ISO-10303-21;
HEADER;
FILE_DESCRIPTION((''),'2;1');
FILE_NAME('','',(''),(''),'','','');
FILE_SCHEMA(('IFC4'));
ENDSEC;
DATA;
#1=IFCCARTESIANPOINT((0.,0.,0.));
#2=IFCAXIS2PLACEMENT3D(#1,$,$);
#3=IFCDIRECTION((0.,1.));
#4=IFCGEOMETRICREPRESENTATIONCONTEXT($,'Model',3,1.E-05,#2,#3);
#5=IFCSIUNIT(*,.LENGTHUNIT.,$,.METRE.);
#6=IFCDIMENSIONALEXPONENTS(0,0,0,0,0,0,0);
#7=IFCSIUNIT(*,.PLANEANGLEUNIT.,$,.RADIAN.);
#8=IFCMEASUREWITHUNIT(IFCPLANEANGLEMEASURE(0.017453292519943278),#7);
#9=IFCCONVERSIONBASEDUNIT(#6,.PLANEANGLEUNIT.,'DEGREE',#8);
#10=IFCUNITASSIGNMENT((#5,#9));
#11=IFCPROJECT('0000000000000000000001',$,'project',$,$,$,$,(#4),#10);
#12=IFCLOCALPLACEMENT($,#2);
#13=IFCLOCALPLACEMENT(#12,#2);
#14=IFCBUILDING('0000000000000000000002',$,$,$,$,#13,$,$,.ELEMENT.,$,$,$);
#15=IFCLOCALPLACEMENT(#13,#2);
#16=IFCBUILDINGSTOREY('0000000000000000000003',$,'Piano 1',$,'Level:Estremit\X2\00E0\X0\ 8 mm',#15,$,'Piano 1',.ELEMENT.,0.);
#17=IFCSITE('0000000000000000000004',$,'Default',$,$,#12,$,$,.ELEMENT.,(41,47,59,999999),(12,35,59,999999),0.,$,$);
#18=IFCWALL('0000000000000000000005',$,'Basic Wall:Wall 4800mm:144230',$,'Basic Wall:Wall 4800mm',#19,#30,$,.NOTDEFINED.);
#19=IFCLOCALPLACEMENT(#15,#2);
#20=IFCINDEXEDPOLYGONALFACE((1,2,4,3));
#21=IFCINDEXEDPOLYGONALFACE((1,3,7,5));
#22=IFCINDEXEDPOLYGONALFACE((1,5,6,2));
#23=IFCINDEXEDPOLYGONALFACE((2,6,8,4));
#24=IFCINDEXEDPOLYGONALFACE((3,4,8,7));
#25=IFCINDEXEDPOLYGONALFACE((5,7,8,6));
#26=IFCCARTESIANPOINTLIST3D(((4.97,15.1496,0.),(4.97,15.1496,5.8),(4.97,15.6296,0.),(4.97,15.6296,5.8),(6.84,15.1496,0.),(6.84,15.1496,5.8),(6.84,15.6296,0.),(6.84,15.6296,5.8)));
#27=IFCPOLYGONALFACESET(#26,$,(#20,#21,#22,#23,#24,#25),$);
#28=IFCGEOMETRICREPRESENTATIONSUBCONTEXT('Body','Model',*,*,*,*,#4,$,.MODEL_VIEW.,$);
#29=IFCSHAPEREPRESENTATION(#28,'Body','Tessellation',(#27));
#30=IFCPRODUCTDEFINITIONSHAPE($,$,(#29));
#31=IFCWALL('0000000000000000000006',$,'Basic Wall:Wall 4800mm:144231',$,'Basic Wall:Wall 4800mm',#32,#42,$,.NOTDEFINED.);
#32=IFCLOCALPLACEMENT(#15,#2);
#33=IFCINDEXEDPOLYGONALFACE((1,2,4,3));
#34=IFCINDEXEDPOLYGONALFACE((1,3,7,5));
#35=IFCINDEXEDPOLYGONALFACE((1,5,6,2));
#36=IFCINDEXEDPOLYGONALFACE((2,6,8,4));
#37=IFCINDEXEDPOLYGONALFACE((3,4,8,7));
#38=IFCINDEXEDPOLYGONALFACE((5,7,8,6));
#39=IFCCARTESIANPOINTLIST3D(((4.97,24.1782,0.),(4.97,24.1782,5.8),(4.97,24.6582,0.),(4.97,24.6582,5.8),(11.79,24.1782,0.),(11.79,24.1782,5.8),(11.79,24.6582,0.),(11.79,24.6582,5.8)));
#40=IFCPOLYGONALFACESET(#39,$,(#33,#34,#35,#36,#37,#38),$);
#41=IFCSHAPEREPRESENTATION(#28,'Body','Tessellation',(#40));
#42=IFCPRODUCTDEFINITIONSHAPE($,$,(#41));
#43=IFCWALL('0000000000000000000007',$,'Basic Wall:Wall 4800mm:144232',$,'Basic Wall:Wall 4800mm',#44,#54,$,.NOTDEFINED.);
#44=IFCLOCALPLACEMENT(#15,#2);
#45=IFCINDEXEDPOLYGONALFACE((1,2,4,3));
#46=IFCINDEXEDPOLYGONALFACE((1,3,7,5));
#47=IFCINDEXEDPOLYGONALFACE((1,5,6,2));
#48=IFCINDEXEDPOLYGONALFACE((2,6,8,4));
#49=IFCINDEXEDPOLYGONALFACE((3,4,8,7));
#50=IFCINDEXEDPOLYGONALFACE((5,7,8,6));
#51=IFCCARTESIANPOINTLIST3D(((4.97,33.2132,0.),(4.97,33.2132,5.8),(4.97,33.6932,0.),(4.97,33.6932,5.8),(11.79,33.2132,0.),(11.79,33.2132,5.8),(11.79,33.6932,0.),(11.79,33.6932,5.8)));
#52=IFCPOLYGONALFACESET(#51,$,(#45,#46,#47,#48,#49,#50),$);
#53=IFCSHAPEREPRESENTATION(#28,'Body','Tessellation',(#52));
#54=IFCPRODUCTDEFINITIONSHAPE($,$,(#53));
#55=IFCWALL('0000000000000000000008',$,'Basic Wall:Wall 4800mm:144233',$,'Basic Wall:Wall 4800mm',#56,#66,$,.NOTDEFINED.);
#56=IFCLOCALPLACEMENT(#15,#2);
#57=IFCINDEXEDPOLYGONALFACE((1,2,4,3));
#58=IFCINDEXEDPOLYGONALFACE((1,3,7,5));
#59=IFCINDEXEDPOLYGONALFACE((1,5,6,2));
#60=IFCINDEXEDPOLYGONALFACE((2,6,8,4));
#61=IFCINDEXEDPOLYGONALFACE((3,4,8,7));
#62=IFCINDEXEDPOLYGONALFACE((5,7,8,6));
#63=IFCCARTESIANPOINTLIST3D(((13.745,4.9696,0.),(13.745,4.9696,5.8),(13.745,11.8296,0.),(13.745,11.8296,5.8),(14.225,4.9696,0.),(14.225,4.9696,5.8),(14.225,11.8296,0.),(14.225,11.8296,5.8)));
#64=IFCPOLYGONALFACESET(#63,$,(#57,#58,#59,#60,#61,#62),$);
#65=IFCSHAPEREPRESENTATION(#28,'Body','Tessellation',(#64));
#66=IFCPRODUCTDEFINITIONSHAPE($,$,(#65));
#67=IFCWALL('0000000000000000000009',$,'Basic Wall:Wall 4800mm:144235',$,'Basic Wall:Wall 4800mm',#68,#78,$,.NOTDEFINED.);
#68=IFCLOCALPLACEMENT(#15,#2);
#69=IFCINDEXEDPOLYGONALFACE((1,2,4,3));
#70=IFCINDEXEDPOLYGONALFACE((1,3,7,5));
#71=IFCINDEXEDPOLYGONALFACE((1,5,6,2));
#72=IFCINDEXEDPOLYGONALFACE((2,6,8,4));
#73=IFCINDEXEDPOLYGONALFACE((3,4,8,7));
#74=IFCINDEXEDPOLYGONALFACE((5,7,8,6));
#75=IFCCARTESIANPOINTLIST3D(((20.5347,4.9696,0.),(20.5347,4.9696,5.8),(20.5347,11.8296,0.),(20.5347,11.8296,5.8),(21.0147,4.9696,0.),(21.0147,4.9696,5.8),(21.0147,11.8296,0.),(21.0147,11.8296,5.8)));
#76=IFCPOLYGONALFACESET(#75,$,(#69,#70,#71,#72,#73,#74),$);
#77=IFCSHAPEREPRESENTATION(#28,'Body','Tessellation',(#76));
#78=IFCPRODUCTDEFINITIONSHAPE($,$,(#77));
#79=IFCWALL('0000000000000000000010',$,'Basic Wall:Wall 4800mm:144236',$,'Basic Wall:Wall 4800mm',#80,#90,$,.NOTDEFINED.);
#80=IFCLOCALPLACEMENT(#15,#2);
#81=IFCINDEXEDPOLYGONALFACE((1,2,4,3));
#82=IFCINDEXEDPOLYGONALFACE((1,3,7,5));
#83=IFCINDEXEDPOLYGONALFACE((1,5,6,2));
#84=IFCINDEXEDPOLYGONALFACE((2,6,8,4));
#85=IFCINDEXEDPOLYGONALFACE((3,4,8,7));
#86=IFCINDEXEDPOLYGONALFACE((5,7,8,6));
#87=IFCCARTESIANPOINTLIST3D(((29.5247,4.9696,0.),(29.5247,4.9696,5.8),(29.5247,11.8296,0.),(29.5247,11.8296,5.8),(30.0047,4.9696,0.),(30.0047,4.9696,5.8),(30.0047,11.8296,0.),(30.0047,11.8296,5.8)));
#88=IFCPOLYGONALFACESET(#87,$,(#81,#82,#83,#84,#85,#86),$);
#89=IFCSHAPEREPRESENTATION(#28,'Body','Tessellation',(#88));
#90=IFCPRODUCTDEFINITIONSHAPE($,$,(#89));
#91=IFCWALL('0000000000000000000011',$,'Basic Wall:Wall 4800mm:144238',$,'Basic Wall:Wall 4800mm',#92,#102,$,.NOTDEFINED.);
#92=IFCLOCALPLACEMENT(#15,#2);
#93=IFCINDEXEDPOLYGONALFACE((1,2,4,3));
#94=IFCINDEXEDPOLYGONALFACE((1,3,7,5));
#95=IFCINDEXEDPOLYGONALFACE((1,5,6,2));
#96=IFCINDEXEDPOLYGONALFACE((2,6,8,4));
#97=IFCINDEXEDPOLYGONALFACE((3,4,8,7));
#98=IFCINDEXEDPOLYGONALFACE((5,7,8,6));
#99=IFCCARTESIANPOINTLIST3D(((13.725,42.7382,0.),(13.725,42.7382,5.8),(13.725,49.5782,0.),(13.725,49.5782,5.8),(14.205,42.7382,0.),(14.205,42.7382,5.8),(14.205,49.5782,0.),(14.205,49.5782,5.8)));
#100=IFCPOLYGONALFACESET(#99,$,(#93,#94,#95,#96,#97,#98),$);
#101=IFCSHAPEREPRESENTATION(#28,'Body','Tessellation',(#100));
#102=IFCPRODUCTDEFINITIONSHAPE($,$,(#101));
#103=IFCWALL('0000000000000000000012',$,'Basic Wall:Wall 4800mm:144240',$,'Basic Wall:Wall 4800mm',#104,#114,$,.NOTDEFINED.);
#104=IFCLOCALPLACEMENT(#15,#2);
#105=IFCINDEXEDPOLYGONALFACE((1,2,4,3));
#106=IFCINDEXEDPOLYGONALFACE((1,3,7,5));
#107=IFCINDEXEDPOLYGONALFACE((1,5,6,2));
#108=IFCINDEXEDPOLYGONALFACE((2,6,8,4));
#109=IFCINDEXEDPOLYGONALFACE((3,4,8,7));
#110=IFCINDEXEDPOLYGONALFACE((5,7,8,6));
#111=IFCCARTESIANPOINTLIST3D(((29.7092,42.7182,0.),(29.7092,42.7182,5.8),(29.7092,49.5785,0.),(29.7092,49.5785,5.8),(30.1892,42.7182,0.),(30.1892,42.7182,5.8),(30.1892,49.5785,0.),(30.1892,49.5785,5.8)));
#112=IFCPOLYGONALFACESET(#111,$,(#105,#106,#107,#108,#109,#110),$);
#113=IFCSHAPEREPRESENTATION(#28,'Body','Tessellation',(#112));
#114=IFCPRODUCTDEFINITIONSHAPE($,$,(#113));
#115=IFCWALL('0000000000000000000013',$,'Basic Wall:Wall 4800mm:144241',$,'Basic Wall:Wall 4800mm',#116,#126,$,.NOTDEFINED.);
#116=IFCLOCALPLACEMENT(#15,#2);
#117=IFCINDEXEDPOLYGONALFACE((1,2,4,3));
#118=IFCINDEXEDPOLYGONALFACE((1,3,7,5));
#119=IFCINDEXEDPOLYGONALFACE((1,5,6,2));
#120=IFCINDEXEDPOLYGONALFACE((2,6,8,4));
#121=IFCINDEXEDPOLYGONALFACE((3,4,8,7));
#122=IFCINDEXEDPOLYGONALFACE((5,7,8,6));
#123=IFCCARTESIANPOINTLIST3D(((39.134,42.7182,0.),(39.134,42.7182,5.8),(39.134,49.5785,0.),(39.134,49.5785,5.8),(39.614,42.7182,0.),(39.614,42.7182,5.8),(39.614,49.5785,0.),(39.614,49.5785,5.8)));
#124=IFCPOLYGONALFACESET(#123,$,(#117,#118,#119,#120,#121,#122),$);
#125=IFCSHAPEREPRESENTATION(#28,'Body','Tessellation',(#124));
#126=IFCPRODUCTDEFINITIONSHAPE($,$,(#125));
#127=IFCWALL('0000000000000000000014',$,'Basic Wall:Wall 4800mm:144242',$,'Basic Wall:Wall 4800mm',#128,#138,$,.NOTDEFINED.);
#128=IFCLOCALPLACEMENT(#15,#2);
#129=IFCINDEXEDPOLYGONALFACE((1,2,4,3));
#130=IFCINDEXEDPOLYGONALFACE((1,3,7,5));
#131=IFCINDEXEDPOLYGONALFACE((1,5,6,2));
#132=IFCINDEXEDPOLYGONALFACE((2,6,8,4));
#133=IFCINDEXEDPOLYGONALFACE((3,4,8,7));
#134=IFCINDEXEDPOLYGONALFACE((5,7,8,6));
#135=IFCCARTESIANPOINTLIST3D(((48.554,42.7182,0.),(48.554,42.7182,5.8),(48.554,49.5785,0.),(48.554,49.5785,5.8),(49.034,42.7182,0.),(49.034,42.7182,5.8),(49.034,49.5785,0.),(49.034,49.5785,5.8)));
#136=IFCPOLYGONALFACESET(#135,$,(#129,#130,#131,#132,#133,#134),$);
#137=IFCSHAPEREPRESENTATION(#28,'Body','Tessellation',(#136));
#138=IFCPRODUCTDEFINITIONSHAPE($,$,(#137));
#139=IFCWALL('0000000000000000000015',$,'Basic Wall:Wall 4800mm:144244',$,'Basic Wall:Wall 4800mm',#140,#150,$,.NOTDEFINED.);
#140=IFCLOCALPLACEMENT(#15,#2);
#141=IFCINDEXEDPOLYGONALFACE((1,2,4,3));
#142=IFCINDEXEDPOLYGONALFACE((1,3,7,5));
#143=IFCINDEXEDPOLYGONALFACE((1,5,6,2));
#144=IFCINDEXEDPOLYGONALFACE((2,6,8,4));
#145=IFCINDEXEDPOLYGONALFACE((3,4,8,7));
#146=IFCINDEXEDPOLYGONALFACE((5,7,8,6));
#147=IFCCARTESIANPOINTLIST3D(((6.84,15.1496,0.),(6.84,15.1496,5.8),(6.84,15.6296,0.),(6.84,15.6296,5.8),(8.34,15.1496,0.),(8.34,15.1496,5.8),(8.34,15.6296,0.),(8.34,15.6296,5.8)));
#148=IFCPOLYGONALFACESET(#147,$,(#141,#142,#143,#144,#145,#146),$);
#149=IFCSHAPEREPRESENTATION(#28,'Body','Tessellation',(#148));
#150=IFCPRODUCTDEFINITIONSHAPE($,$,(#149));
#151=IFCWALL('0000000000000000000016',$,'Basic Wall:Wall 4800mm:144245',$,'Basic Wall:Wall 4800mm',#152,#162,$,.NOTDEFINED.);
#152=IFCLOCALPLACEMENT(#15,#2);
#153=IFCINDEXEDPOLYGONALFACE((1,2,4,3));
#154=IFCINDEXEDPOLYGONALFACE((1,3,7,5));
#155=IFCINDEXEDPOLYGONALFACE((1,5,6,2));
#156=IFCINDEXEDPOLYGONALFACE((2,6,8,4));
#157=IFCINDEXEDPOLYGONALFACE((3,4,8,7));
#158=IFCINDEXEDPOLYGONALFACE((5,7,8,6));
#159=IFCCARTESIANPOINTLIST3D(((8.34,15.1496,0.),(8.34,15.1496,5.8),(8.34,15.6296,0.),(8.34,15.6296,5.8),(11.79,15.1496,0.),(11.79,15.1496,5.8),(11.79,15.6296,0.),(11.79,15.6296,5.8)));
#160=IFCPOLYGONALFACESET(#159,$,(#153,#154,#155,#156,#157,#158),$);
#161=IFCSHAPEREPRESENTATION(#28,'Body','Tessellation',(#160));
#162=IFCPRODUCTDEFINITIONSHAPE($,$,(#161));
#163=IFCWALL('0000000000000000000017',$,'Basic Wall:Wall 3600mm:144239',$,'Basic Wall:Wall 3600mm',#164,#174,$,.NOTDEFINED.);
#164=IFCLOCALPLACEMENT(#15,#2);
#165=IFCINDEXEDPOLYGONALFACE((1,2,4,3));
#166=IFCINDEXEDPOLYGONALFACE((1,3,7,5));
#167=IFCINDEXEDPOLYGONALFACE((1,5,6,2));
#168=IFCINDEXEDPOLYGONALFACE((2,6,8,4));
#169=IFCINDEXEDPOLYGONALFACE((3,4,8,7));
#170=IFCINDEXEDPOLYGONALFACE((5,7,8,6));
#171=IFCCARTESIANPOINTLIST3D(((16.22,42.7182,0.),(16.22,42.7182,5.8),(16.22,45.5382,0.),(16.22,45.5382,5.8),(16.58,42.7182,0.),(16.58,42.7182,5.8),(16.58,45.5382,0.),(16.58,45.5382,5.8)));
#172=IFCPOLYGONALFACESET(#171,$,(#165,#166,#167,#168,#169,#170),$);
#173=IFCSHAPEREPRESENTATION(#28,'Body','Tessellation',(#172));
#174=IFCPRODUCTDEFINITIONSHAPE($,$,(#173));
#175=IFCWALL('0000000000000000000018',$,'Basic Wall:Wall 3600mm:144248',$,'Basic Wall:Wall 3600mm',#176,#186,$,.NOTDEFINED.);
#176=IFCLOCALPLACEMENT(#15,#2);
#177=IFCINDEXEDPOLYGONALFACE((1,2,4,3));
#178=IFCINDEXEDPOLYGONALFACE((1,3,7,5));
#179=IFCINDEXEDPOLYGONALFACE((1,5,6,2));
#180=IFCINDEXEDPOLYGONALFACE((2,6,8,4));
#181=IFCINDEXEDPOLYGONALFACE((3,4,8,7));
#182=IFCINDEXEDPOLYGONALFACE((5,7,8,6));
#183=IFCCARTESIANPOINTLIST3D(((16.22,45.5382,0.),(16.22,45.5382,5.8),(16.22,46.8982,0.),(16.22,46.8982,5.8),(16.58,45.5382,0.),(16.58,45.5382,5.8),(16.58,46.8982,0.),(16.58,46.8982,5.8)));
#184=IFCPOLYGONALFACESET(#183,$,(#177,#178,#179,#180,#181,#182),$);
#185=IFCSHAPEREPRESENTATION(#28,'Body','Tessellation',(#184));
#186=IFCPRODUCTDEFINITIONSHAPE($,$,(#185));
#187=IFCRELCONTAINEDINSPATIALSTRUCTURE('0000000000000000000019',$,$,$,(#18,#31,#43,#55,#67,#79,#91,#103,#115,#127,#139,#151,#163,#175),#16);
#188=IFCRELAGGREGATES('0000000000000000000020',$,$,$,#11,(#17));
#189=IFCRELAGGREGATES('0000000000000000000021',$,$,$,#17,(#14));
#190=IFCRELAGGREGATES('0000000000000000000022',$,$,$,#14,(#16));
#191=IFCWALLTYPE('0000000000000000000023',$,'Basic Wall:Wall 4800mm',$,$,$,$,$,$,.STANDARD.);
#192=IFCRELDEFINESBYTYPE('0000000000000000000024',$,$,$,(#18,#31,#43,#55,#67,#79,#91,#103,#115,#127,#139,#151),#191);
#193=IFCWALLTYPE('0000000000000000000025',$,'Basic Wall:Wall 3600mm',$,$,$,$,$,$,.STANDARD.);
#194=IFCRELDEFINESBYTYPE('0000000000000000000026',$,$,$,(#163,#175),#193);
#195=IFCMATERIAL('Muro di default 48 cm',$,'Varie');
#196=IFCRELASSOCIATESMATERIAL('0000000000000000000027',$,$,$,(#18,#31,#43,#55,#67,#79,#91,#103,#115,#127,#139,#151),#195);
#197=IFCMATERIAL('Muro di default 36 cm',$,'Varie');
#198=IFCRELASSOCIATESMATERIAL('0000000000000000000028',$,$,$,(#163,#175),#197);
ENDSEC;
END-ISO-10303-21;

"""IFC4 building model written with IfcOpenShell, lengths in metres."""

from ifc_helpers import new_model, entity, si_unit, converted_unit, direction, frame, origin, place, context, subcontext, project, spatial, indexed_curve, outline, extrude, material, type_object, element, save


model = new_model("IFC4")

# Units and contexts
model_context = context("Model", 3, precision=1e-05, world=origin(), true_north=direction((0.0, 1.0)))
body_context = subcontext(model_context, "Body", "Model", "MODEL_VIEW")
ifc_project = project(units=[si_unit("LENGTHUNIT", "METRE"), converted_unit("PLANEANGLEUNIT", "DEGREE", entity("IfcPlaneAngleMeasure", 0.017453292519943278), si_unit("PLANEANGLEUNIT", "RADIAN"), dimensions=[0, 0, 0, 0, 0, 0, 0])], contexts=[model_context])

# Site, building, storey
site_placement = place(None, origin())
site = spatial("IfcSite", under=ifc_project, at=site_placement, Name="Default", CompositionType="ELEMENT", RefLatitude=(41, 47, 59, 999999), RefLongitude=(12, 35, 59, 999999), RefElevation=0.0)
building_placement = place(site_placement, origin())
building = spatial("IfcBuilding", under=site, at=building_placement, CompositionType="ELEMENT")
storey_placement = place(building_placement, origin())
storey = spatial("IfcBuildingStorey", under=building, at=storey_placement, Name="Piano 1", ObjectType="Level:Estremità 8 mm", LongName="Piano 1", CompositionType="ELEMENT", Elevation=0.0)

# Walls
ifc_material_1 = material(Name="Muro di default 48 cm", Category="Varie")
wall_type_1 = type_object("IfcWallType", Name="Basic Wall:Wall 4800mm", PredefinedType="STANDARD")
wall_1_placement = place(storey_placement, frame((4.97, 15.3896, 0.0)))
element("IfcWall", 1, at=wall_1_placement, inside=storey, type_object=wall_type_1, material=ifc_material_1, Name="Basic Wall:Wall 4800mm:144230", ObjectType="Basic Wall:Wall 4800mm", PredefinedType="NOTDEFINED", context=body_context, shape_type="SweptSolid", body=[
    extrude(outline(indexed_curve([(1.87, 0.24), (0.0, 0.24), (0.0, -0.24), (1.87, -0.24), (1.87, 0.24)], self_intersect=False)), origin(), (0.0, 0.0, 1.0), 5.8),
])
wall_2_placement = place(storey_placement, frame((4.97, 24.4182, 0.0)))
element("IfcWall", 2, at=wall_2_placement, inside=storey, type_object=wall_type_1, material=ifc_material_1, Name="Basic Wall:Wall 4800mm:144231", ObjectType="Basic Wall:Wall 4800mm", PredefinedType="NOTDEFINED", context=body_context, shape_type="SweptSolid", body=[
    extrude(outline(indexed_curve([(6.82, 0.24), (0.0, 0.24), (0.0, -0.24), (6.82, -0.24), (6.82, 0.24)], self_intersect=False)), origin(), (0.0, 0.0, 1.0), 5.8),
])
wall_3_placement = place(storey_placement, frame((4.97, 33.4532, 0.0)))
element("IfcWall", 3, at=wall_3_placement, inside=storey, type_object=wall_type_1, material=ifc_material_1, Name="Basic Wall:Wall 4800mm:144232", ObjectType="Basic Wall:Wall 4800mm", PredefinedType="NOTDEFINED", context=body_context, shape_type="SweptSolid", body=[
    extrude(outline(indexed_curve([(6.82, 0.24), (0.0, 0.24), (0.0, -0.24), (6.82, -0.24), (6.82, 0.24)], self_intersect=False)), origin(), (0.0, 0.0, 1.0), 5.8),
])
wall_4_placement = place(storey_placement, frame((13.985, 4.9696, 0.0), z_axis=(0.0, 0.0, 1.0), x_axis=(0.0, 1.0, 0.0)))
element("IfcWall", 4, at=wall_4_placement, inside=storey, type_object=wall_type_1, material=ifc_material_1, Name="Basic Wall:Wall 4800mm:144233", ObjectType="Basic Wall:Wall 4800mm", PredefinedType="NOTDEFINED", context=body_context, shape_type="SweptSolid", body=[
    extrude(outline(indexed_curve([(6.86, 0.24), (0.0, 0.24), (0.0, -0.24), (6.86, -0.24), (6.86, 0.24)], self_intersect=False)), origin(), (0.0, 0.0, 1.0), 5.8),
])
for number, where, z_axis, x_axis, name in (
    (5, (20.7747, 4.9696, 0.0), (0.0, 0.0, 1.0), (0.0, 1.0, 0.0), "Basic Wall:Wall 4800mm:144235"),
    (6, (29.7647, 4.9696, 0.0), (0.0, 0.0, 1.0), (0.0, 1.0, 0.0), "Basic Wall:Wall 4800mm:144236"),
):
    element("IfcWall", number, at=place(storey_placement, frame(where, z_axis=z_axis, x_axis=x_axis)), inside=storey, type_object=wall_type_1, material=ifc_material_1, Name=name, ObjectType="Basic Wall:Wall 4800mm", PredefinedType="NOTDEFINED", context=body_context, shape_type="SweptSolid", body=[
        extrude(outline(indexed_curve([(6.86, 0.24), (0.0, 0.24), (0.0, -0.24), (6.86, -0.24), (6.86, 0.24)], self_intersect=False)), origin(), (0.0, 0.0, 1.0), 5.8),
    ])
wall_5_placement = place(storey_placement, frame((13.965, 42.7382, 0.0), z_axis=(0.0, 0.0, 1.0), x_axis=(0.0, 1.0, 0.0)))
element("IfcWall", 7, at=wall_5_placement, inside=storey, type_object=wall_type_1, material=ifc_material_1, Name="Basic Wall:Wall 4800mm:144238", ObjectType="Basic Wall:Wall 4800mm", PredefinedType="NOTDEFINED", context=body_context, shape_type="SweptSolid", body=[
    extrude(outline(indexed_curve([(6.84, 0.24), (0.0, 0.24), (0.0, -0.24), (6.84, -0.24), (6.84, 0.24)], self_intersect=False)), origin(), (0.0, 0.0, 1.0), 5.8),
])
wall_6_placement = place(storey_placement, frame((29.9492, 42.7182, 0.0), z_axis=(0.0, 0.0, 1.0), x_axis=(0.0, 1.0, 0.0)))
element("IfcWall", 8, at=wall_6_placement, inside=storey, type_object=wall_type_1, material=ifc_material_1, Name="Basic Wall:Wall 4800mm:144240", ObjectType="Basic Wall:Wall 4800mm", PredefinedType="NOTDEFINED", context=body_context, shape_type="SweptSolid", body=[
    extrude(outline(indexed_curve([(6.8603, 0.24), (0.0, 0.24), (0.0, -0.24), (6.8603, -0.24), (6.8603, 0.24)], self_intersect=False)), origin(), (0.0, 0.0, 1.0), 5.8),
])
for number, where, z_axis, x_axis, name in (
    (9, (39.374, 42.7182, 0.0), (0.0, 0.0, 1.0), (0.0, 1.0, 0.0), "Basic Wall:Wall 4800mm:144241"),
    (10, (48.794, 42.7182, 0.0), (0.0, 0.0, 1.0), (0.0, 1.0, 0.0), "Basic Wall:Wall 4800mm:144242"),
):
    element("IfcWall", number, at=place(storey_placement, frame(where, z_axis=z_axis, x_axis=x_axis)), inside=storey, type_object=wall_type_1, material=ifc_material_1, Name=name, ObjectType="Basic Wall:Wall 4800mm", PredefinedType="NOTDEFINED", context=body_context, shape_type="SweptSolid", body=[
        extrude(outline(indexed_curve([(6.8603, 0.24), (0.0, 0.24), (0.0, -0.24), (6.8603, -0.24), (6.8603, 0.24)], self_intersect=False)), origin(), (0.0, 0.0, 1.0), 5.8),
    ])
wall_7_placement = place(storey_placement, frame((6.84, 15.3896, 0.0)))
element("IfcWall", 11, at=wall_7_placement, inside=storey, type_object=wall_type_1, material=ifc_material_1, Name="Basic Wall:Wall 4800mm:144244", ObjectType="Basic Wall:Wall 4800mm", PredefinedType="NOTDEFINED", context=body_context, shape_type="SweptSolid", body=[
    extrude(outline(indexed_curve([(1.5, 0.24), (0.0, 0.24), (0.0, -0.24), (1.5, -0.24), (1.5, 0.24)], self_intersect=False)), origin(), (0.0, 0.0, 1.0), 5.8),
])
wall_8_placement = place(storey_placement, frame((8.34, 15.3896, 0.0)))
element("IfcWall", 12, at=wall_8_placement, inside=storey, type_object=wall_type_1, material=ifc_material_1, Name="Basic Wall:Wall 4800mm:144245", ObjectType="Basic Wall:Wall 4800mm", PredefinedType="NOTDEFINED", context=body_context, shape_type="SweptSolid", body=[
    extrude(outline(indexed_curve([(3.45, 0.24), (0.0, 0.24), (0.0, -0.24), (3.45, -0.24), (3.45, 0.24)], self_intersect=False)), origin(), (0.0, 0.0, 1.0), 5.8),
])
ifc_material_2 = material(Name="Muro di default 36 cm", Category="Varie")
wall_type_2 = type_object("IfcWallType", Name="Basic Wall:Wall 3600mm", PredefinedType="STANDARD")
wall_9_placement = place(storey_placement, frame((16.4, 42.7182, 0.0), z_axis=(0.0, 0.0, 1.0), x_axis=(0.0, 1.0, 0.0)))
element("IfcWall", 13, at=wall_9_placement, inside=storey, type_object=wall_type_2, material=ifc_material_2, Name="Basic Wall:Wall 3600mm:144239", ObjectType="Basic Wall:Wall 3600mm", PredefinedType="NOTDEFINED", context=body_context, shape_type="SweptSolid", body=[
    extrude(outline(indexed_curve([(2.82, 0.18), (0.0, 0.18), (0.0, -0.18), (2.82, -0.18), (2.82, 0.18)], self_intersect=False)), origin(), (0.0, 0.0, 1.0), 5.8),
])
wall_10_placement = place(storey_placement, frame((16.4, 45.5382, 0.0), z_axis=(0.0, 0.0, 1.0), x_axis=(0.0, 1.0, 0.0)))
element("IfcWall", 14, at=wall_10_placement, inside=storey, type_object=wall_type_2, material=ifc_material_2, Name="Basic Wall:Wall 3600mm:144248", ObjectType="Basic Wall:Wall 3600mm", PredefinedType="NOTDEFINED", context=body_context, shape_type="SweptSolid", body=[
    extrude(outline(indexed_curve([(1.36, 0.18), (0.0, 0.18), (0.0, -0.18), (1.36, -0.18), (1.36, 0.18)], self_intersect=False)), origin(), (0.0, 0.0, 1.0), 5.8),
])

save(model, "model.ifc")
